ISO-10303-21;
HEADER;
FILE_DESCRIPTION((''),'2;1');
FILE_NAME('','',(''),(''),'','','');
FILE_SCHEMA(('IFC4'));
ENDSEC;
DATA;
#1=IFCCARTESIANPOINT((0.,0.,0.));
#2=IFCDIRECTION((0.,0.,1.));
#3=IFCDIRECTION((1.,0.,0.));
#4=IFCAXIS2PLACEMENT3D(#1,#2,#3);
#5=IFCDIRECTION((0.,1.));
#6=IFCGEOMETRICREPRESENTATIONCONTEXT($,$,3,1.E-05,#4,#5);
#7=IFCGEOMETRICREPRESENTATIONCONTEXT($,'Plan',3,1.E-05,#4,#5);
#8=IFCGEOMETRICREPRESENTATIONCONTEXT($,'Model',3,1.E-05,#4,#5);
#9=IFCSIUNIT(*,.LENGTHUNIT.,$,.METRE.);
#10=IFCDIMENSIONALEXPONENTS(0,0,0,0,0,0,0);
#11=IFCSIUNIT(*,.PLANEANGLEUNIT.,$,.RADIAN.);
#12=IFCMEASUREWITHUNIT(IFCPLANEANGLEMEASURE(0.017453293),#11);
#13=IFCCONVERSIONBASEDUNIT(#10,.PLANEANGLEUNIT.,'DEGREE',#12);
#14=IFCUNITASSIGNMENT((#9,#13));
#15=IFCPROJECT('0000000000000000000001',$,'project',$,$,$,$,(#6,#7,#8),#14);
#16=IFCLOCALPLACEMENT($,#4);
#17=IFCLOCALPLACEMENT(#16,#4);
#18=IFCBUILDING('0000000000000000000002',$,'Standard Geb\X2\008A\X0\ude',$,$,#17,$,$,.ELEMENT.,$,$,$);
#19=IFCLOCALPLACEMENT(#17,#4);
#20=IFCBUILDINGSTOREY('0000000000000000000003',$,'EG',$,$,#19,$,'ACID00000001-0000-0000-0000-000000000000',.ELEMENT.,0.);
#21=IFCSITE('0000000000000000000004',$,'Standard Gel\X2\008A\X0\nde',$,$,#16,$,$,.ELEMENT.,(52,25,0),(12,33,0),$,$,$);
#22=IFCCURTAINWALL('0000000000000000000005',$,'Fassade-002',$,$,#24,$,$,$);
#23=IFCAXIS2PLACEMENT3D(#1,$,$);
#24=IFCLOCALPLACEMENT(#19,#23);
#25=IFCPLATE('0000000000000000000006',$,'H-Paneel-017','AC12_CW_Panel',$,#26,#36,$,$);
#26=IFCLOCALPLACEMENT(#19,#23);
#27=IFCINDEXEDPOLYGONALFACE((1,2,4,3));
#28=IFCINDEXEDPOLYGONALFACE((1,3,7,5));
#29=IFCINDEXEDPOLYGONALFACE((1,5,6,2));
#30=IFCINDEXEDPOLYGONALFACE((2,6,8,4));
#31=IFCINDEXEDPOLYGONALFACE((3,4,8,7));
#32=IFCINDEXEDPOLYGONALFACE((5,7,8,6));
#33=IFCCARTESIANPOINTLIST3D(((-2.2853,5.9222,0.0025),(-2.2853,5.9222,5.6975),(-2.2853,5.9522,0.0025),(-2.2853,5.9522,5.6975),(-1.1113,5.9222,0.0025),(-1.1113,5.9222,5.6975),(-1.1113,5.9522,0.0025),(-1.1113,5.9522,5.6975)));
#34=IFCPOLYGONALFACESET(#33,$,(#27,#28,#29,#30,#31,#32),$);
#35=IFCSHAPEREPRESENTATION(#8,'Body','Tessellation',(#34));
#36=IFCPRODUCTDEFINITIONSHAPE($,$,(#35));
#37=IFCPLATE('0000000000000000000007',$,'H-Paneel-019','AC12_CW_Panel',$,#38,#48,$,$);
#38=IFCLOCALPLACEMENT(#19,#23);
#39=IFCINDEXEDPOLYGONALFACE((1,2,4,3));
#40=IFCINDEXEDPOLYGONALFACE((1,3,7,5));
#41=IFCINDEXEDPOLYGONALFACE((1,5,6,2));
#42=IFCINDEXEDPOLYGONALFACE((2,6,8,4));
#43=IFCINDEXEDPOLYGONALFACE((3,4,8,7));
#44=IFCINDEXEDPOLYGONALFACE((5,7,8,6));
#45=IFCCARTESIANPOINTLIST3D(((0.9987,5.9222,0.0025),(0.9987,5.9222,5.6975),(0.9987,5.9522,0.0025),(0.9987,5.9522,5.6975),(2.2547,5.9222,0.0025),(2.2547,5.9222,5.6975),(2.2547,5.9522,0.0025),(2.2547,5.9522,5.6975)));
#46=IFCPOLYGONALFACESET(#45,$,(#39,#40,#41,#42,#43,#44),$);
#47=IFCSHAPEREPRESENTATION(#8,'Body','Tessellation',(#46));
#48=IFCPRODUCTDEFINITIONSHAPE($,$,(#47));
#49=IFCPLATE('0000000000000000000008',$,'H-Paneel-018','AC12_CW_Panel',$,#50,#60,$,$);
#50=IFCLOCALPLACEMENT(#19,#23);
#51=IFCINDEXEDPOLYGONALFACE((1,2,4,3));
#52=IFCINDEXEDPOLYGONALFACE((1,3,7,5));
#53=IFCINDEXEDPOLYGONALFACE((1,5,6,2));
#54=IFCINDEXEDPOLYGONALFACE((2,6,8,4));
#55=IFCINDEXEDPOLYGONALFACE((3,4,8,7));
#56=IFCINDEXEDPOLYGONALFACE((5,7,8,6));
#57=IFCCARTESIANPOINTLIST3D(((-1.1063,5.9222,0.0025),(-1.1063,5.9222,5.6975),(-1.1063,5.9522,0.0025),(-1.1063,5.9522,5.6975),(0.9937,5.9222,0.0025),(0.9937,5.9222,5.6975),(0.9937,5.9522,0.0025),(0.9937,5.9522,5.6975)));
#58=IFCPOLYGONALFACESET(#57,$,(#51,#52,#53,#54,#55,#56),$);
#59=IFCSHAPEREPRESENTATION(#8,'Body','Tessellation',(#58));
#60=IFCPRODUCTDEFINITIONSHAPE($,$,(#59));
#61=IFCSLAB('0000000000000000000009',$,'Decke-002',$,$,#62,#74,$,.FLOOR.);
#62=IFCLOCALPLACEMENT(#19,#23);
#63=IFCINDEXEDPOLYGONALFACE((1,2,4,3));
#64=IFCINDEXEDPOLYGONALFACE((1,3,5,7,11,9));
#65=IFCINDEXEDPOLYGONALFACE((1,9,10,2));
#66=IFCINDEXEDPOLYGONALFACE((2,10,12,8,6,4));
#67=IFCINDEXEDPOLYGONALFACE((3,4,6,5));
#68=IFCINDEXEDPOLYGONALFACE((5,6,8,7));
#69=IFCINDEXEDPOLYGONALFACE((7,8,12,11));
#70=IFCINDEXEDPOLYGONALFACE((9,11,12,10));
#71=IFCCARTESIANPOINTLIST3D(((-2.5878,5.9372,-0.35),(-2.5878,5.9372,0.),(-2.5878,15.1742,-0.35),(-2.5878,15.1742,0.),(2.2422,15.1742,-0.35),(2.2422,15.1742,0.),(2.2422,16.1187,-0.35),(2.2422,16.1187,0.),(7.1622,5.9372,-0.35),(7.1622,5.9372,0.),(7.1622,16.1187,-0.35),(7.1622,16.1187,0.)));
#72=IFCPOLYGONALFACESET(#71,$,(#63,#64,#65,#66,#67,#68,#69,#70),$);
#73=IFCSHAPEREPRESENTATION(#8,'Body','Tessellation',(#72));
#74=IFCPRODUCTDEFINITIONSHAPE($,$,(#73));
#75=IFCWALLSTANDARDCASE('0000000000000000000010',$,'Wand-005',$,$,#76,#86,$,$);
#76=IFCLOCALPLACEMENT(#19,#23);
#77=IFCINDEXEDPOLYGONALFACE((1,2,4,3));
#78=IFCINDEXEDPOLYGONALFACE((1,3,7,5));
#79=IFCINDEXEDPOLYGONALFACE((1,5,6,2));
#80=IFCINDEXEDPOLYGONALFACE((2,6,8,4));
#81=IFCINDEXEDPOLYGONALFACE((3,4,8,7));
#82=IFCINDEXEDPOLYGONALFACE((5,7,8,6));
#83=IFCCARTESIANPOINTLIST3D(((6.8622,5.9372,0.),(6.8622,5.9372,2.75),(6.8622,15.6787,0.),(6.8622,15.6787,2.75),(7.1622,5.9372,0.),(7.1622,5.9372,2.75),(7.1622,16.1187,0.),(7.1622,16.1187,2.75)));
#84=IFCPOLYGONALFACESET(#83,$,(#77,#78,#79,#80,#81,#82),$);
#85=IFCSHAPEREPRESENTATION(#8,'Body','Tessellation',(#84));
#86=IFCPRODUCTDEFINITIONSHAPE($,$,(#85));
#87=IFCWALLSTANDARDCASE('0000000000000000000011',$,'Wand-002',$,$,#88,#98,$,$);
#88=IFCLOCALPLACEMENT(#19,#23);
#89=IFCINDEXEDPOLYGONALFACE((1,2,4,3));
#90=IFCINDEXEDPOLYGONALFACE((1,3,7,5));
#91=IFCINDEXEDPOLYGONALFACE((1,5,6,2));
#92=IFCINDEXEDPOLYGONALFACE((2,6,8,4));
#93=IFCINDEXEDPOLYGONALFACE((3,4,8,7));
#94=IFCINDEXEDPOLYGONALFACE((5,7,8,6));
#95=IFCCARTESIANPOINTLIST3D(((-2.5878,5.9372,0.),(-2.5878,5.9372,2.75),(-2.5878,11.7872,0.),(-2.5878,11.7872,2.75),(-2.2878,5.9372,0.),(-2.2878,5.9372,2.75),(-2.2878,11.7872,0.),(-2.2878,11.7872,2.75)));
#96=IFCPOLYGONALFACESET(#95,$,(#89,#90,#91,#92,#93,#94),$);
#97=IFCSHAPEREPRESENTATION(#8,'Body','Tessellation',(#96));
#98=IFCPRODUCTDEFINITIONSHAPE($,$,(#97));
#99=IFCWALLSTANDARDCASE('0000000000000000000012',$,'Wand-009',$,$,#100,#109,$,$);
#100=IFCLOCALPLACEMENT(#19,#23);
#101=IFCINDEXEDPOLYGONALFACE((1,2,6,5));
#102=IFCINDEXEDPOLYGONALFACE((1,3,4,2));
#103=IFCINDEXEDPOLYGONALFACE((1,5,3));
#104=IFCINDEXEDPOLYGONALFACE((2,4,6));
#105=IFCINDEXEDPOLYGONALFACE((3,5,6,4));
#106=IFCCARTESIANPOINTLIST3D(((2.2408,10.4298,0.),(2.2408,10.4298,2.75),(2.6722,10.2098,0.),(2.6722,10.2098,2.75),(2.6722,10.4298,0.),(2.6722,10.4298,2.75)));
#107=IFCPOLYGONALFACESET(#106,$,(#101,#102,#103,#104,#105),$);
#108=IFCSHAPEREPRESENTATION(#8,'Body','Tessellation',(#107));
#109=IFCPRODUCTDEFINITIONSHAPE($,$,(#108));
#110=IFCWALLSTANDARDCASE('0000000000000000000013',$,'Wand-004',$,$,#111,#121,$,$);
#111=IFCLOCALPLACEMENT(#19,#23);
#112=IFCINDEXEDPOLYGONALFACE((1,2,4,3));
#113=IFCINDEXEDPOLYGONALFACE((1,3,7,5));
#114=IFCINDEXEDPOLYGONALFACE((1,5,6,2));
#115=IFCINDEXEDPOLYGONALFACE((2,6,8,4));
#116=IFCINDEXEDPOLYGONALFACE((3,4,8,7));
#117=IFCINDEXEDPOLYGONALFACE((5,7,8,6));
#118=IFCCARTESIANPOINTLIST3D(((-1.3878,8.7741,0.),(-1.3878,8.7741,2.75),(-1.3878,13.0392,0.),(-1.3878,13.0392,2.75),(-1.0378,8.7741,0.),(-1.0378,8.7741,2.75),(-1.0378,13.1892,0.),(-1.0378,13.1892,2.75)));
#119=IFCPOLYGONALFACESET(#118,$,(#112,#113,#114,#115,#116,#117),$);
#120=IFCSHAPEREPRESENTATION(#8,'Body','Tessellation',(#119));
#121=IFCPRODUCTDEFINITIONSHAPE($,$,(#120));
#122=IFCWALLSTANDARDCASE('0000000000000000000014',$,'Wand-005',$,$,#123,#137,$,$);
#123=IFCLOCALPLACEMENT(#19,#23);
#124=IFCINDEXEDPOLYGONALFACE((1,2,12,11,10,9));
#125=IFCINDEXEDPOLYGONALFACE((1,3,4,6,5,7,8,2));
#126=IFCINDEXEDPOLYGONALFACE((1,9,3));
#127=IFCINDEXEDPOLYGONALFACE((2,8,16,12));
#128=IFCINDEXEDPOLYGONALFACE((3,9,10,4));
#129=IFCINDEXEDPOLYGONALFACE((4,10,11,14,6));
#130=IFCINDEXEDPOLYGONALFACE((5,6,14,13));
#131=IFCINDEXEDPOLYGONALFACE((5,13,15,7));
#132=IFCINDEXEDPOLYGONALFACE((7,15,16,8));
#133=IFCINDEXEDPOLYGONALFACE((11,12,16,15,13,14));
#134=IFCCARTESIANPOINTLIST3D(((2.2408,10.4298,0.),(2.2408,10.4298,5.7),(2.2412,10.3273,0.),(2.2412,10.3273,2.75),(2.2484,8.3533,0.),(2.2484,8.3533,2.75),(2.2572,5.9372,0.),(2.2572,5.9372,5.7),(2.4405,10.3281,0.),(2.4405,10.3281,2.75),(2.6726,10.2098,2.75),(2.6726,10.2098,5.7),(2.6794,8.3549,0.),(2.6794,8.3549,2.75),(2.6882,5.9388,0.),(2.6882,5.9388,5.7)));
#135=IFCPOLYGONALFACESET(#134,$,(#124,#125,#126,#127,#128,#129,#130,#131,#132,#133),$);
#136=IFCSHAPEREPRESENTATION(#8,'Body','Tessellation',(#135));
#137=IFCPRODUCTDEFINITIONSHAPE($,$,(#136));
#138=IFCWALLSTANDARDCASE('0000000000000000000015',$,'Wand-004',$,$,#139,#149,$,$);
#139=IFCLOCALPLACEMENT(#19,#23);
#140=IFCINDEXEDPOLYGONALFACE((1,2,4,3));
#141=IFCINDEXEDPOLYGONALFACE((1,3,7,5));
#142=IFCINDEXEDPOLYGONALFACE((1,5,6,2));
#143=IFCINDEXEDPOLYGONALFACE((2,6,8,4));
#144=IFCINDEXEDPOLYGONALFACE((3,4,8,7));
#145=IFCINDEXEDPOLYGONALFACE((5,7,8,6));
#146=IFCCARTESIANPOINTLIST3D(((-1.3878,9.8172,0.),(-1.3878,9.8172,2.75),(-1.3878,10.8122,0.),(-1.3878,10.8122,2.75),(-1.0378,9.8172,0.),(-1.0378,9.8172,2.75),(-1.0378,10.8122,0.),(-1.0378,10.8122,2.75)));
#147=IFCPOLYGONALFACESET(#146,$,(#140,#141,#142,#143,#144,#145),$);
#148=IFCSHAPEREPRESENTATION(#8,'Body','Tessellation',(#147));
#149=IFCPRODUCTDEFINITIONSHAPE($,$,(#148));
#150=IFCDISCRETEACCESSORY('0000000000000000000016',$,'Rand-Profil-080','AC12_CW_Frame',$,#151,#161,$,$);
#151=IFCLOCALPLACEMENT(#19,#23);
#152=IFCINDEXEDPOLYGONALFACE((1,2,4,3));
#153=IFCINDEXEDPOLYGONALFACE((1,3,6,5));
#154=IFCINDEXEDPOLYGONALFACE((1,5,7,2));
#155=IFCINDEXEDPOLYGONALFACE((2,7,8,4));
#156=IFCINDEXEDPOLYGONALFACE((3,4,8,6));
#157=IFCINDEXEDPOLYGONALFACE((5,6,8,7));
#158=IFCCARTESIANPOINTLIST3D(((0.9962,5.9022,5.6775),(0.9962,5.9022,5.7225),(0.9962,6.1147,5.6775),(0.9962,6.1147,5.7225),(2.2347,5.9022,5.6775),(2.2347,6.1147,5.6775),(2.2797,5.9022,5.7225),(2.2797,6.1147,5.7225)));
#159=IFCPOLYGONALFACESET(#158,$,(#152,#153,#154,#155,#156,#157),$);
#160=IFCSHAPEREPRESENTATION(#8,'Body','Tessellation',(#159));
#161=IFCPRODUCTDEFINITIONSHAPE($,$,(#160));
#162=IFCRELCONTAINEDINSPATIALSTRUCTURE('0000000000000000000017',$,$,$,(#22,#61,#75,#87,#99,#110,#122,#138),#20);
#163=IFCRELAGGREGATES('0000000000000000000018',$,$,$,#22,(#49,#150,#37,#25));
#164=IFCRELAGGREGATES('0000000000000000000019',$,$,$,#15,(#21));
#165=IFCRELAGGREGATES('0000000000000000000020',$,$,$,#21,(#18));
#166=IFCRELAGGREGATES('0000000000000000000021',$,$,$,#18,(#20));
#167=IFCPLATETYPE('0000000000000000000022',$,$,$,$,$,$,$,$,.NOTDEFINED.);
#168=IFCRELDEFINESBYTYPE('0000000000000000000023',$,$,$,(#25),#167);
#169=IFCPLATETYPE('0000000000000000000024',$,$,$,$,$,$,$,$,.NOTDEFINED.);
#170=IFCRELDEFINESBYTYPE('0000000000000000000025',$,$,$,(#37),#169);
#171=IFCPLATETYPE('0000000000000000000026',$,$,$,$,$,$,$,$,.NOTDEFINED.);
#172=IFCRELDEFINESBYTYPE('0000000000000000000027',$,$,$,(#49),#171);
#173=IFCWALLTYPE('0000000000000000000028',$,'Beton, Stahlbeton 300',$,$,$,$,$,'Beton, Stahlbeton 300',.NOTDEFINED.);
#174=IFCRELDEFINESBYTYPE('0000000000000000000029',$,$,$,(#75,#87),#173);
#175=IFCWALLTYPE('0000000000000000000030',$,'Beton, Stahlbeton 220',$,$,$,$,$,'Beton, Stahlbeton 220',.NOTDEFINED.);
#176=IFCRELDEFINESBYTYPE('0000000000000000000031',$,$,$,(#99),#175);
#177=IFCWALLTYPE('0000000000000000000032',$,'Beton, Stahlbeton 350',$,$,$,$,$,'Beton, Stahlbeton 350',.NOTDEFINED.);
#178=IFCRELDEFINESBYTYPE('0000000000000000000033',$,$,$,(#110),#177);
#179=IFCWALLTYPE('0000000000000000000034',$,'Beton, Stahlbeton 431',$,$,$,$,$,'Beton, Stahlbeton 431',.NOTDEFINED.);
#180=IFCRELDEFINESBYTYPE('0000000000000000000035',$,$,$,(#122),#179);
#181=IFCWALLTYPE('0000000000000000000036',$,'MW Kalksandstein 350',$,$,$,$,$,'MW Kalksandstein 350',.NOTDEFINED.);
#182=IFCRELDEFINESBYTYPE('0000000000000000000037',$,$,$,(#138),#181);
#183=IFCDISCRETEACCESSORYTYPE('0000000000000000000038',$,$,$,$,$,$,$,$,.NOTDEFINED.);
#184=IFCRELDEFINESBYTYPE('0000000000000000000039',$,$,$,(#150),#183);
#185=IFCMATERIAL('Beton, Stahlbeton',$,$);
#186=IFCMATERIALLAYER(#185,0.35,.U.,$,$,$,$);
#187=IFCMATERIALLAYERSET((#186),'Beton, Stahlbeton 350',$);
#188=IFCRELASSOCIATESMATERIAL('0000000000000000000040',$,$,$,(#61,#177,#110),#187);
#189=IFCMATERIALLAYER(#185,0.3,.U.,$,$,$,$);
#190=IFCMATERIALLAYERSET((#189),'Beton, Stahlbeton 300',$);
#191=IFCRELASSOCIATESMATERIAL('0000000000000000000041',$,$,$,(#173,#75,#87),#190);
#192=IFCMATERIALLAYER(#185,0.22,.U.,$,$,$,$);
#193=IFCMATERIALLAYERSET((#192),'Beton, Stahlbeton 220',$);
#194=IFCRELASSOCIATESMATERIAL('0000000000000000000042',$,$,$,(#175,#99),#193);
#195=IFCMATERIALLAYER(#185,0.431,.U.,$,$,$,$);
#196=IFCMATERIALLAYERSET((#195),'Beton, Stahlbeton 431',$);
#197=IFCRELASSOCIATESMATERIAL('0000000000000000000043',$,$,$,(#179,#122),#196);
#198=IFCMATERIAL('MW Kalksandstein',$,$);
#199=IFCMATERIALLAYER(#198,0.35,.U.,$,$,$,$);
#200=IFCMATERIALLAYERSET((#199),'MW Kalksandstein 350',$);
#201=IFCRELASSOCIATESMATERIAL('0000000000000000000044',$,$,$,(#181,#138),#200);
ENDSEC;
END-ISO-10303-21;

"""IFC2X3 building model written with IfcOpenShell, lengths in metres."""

from ifc_helpers import new_model, entity, si_unit, converted_unit, direction, frame, frame_2d, origin_with_axes, place, context, project, spatial, polyline, rectangle, outline, extrude, source, transform, mapped, material, layer, layer_set, layer_usage, type_object, type_shapes, element, aggregate, save


model = new_model("IFC2X3")

# Units and contexts
model_context = context("Model", 3, precision=1e-05, world=origin_with_axes(), true_north=direction((0.0, 1.0)))
plan_context = context("Plan", 3, precision=1e-05, world=origin_with_axes(), true_north=direction((0.0, 1.0)))
context_of_model = context(None, 3, precision=1e-05, world=origin_with_axes(), true_north=direction((0.0, 1.0)))
ifc_project = project(units=[si_unit("LENGTHUNIT", "METRE"), converted_unit("PLANEANGLEUNIT", "DEGREE", entity("IfcPlaneAngleMeasure", 0.017453293), si_unit("PLANEANGLEUNIT", "RADIAN"), dimensions=[0, 0, 0, 0, 0, 0, 0])], contexts=[context_of_model, plan_context, model_context])

# Site, building, storey
site_placement = place(None, origin_with_axes())
site = spatial("IfcSite", under=ifc_project, at=site_placement, Name="Standard Gel\u008ande", CompositionType="ELEMENT", RefLatitude=(52, 25, 0), RefLongitude=(12, 33, 0))
building_placement = place(site_placement, origin_with_axes())
building = spatial("IfcBuilding", under=site, at=building_placement, Name="Standard Geb\u008aude", CompositionType="ELEMENT")
storey_placement = place(building_placement, origin_with_axes())
storey = spatial("IfcBuildingStorey", under=building, at=storey_placement, Name="EG", LongName="ACID00000001-0000-0000-0000-000000000000", CompositionType="ELEMENT", Elevation=0.0)

# Curtain wall, plates
curtain_wall_placement = place(storey_placement, frame((-2.2878, 5.9372, 0.0), z_axis=(0.0, 0.0, 1.0), x_axis=(1.0, 0.0, 0.0)))
curtain_wall = element("IfcCurtainWall", 1, at=curtain_wall_placement, inside=storey, Name="Fassade-002")
plate_type_1 = type_object("IfcPlateType", PredefinedType="NOTDEFINED")
shared_shape_1 = source(origin_with_axes(), model_context, "Body", "SweptSolid", [
    extrude(outline(polyline([(0.0, 0.0), (1.174, 0.0), (1.174, -0.03), (0.0, -0.03), (0.0, 0.0)])), origin_with_axes(), (0.0, 0.0, 1.0), 5.695),
])
type_shapes(plate_type_1, [shared_shape_1])
plate_1_placement = place(storey_placement, frame((-2.2853, 5.9522, 0.0025), z_axis=(0.0, 0.0, 1.0), x_axis=(1.0, 0.0, 0.0)))
plate_1 = element("IfcPlate", 2, at=plate_1_placement, type_object=plate_type_1, Name="H-Paneel-017", Description="AC12_CW_Panel", context=model_context, shape_type="MappedRepresentation", body=[
    mapped(shared_shape_1, transform((0.0, 0.0, 0.0), scale=1.0)),
])
plate_type_2 = type_object("IfcPlateType", PredefinedType="NOTDEFINED")
shared_shape_2 = source(origin_with_axes(), model_context, "Body", "SweptSolid", [
    extrude(outline(polyline([(0.0, 0.0), (1.256, 0.0), (1.256, -0.03), (0.0, -0.03), (0.0, 0.0)])), origin_with_axes(), (0.0, 0.0, 1.0), 5.695),
])
type_shapes(plate_type_2, [shared_shape_2])
plate_2_placement = place(storey_placement, frame((0.9987, 5.9522, 0.0025), z_axis=(0.0, 0.0, 1.0), x_axis=(1.0, 0.0, 0.0)))
plate_2 = element("IfcPlate", 3, at=plate_2_placement, type_object=plate_type_2, Name="H-Paneel-019", Description="AC12_CW_Panel", context=model_context, shape_type="MappedRepresentation", body=[
    mapped(shared_shape_2, transform((0.0, 0.0, 0.0), scale=1.0)),
])
plate_type_3 = type_object("IfcPlateType", PredefinedType="NOTDEFINED")
shared_shape_3 = source(origin_with_axes(), model_context, "Body", "SweptSolid", [
    extrude(outline(polyline([(0.0, 0.0), (2.1, 0.0), (2.1, -0.03), (0.0, -0.03), (0.0, 0.0)])), origin_with_axes(), (0.0, 0.0, 1.0), 5.695),
])
type_shapes(plate_type_3, [shared_shape_3])
plate_3_placement = place(storey_placement, frame((-1.1063, 5.9522, 0.0025), z_axis=(0.0, 0.0, 1.0), x_axis=(1.0, 0.0, 0.0)))
plate_3 = element("IfcPlate", 4, at=plate_3_placement, type_object=plate_type_3, Name="H-Paneel-018", Description="AC12_CW_Panel", context=model_context, shape_type="MappedRepresentation", body=[
    mapped(shared_shape_3, transform((0.0, 0.0, 0.0), scale=1.0)),
])

# Slab
ifc_material_1 = material(Name="Beton, Stahlbeton")
ifc_layer_1 = layer(ifc_material_1, 0.35, ventilated="UNKNOWN")
ifc_layer_set_1 = layer_set([ifc_layer_1], Name="Beton, Stahlbeton 350")
ifc_layer_usage_1 = layer_usage(ifc_layer_set_1, "AXIS3", "NEGATIVE", 0.35)
slab_placement = place(storey_placement, frame((-2.5878, 5.9372, -0.35), z_axis=(0.0, 0.0, 1.0), x_axis=(0.0, 1.0, 0.0)))
element("IfcSlab", 5, at=slab_placement, inside=storey, material=ifc_layer_usage_1, Name="Decke-002", PredefinedType="FLOOR", context=model_context, shape_type="SweptSolid", body=[
    extrude(outline(polyline([(0.0, 0.0), (9.237, 0.0), (9.237, -4.83), (10.1815, -4.83), (10.1815, -9.75), (0.0, -9.75), (0.0, 0.0)])), origin_with_axes(), (0.0, 0.0, 1.0), 0.35),
])

# Walls
ifc_layer_2 = layer(ifc_material_1, 0.3, ventilated="UNKNOWN")
ifc_layer_set_2 = layer_set([ifc_layer_2], Name="Beton, Stahlbeton 300")
ifc_layer_usage_2 = layer_usage(ifc_layer_set_2, "AXIS2", "POSITIVE", 0.0)
wall_type_1 = type_object("IfcWallType", Name="Beton, Stahlbeton 300", ElementType="Beton, Stahlbeton 300", PredefinedType="NOTDEFINED", material=ifc_layer_set_2)
wall_1_placement = place(storey_placement, frame((7.1622, 5.9372, 0.0), z_axis=(0.0, 0.0, 1.0), x_axis=(0.0, 1.0, 0.0)))
element("IfcWallStandardCase", 6, at=wall_1_placement, inside=storey, type_object=wall_type_1, material=ifc_layer_usage_2, Name="Wand-005", context=model_context, shape_type="SweptSolid", body=[
    extrude(outline(polyline([(0.0, 0.0), (10.1815, 0.0), (9.7415, 0.3), (0.0, 0.3), (0.0, 0.0)])), origin_with_axes(), (0.0, 0.0, 1.0), 2.75),
])
ifc_layer_usage_3 = layer_usage(ifc_layer_set_2, "AXIS2", "POSITIVE", 0.0)
wall_2_placement = place(storey_placement, frame((-2.5878, 11.7872, 0.0), z_axis=(0.0, 0.0, 1.0), x_axis=(0.0, -1.0, 0.0)))
element("IfcWallStandardCase", 7, at=wall_2_placement, inside=storey, type_object=wall_type_1, material=ifc_layer_usage_3, Name="Wand-002", context=model_context, shape_type="SweptSolid", body=[
    extrude(outline(polyline([(0.0, 0.0), (5.85, 0.0), (5.85, 0.3), (0.0, 0.3), (0.0, 0.0)])), origin_with_axes(), (0.0, 0.0, 1.0), 2.75),
])
ifc_layer_3 = layer(ifc_material_1, 0.22, ventilated="UNKNOWN")
ifc_layer_set_3 = layer_set([ifc_layer_3], Name="Beton, Stahlbeton 220")
ifc_layer_usage_4 = layer_usage(ifc_layer_set_3, "AXIS2", "NEGATIVE", 0.0)
wall_type_2 = type_object("IfcWallType", Name="Beton, Stahlbeton 220", ElementType="Beton, Stahlbeton 220", PredefinedType="NOTDEFINED", material=ifc_layer_set_3)
wall_3_placement = place(storey_placement, frame((2.6722, 10.2098, 0.0), z_axis=(0.0, 0.0, 1.0), x_axis=(-1.0, 0.0, 0.0)))
element("IfcWallStandardCase", 8, at=wall_3_placement, inside=storey, type_object=wall_type_2, material=ifc_layer_usage_4, Name="Wand-009", context=model_context, shape_type="SweptSolid", body=[
    extrude(outline(polyline([(0.0, -0.22), (0.4313, -0.22), (0.0, 0.0), (0.0, 0.0), (0.0, -0.22)])), origin_with_axes(), (0.0, 0.0, 1.0), 2.75),
])
ifc_layer_usage_5 = layer_usage(ifc_layer_set_1, "AXIS2", "NEGATIVE", 0.0)
wall_type_3 = type_object("IfcWallType", Name="Beton, Stahlbeton 350", ElementType="Beton, Stahlbeton 350", PredefinedType="NOTDEFINED", material=ifc_layer_set_1)
wall_4_placement = place(storey_placement, frame((-1.3878, 8.7741, 0.0), z_axis=(0.0, 0.0, 1.0), x_axis=(0.0, 1.0, 0.0)))
element("IfcWallStandardCase", 9, at=wall_4_placement, inside=storey, type_object=wall_type_3, material=ifc_layer_usage_5, Name="Wand-004", context=model_context, shape_type="SweptSolid", body=[
    extrude(outline(polyline([(0.0, -0.35), (4.4151, -0.35), (4.2651, 0.0), (0.0, 0.0), (0.0, -0.35)])), origin_with_axes(), (0.0, 0.0, 1.0), 2.75),
])

# Wall, opening
ifc_layer_4 = layer(ifc_material_1, 0.431, ventilated="UNKNOWN")
ifc_layer_set_4 = layer_set([ifc_layer_4], Name="Beton, Stahlbeton 431")
ifc_layer_usage_6 = layer_usage(ifc_layer_set_4, "AXIS2", "NEGATIVE", 0.0)
wall_type_4 = type_object("IfcWallType", Name="Beton, Stahlbeton 431", ElementType="Beton, Stahlbeton 431", PredefinedType="NOTDEFINED", material=ifc_layer_set_4)
wall_5_placement = place(storey_placement, frame((2.2572, 5.9372, 0.0), z_axis=(0.0, 0.0, 1.0), x_axis=(-0.003631, 0.999993, 0.0)))
wall_5 = element("IfcWallStandardCase", 10, at=wall_5_placement, inside=storey, type_object=wall_type_4, material=ifc_layer_usage_6, Name="Wand-005", context=model_context, shape_type="SweptSolid", body=[
    extrude(outline(polyline([(0.0, -0.431), (4.2711, -0.431), (4.4926, 0.0), (0.0, 0.0), (0.0, -0.431)])), origin_with_axes(), (0.0, 0.0, 1.0), 5.7),
])
opening_placement = place(wall_5_placement, frame((3.4032, -0.431, 0.0), z_axis=(0.0, 0.0, 1.0), x_axis=(1.0, 0.0, 0.0)))
element("IfcOpeningElement", 11, at=opening_placement, cuts=wall_5, ObjectType="Opening", context=model_context, shape_type="SweptSolid", body=[
    extrude(rectangle(XDim=1.974, YDim=2.75, at=frame_2d((0.0, 1.375), x_axis=(1.0, 0.0))), frame((0.0, 0.0, 0.0), z_axis=(0.0, 1.0, 0.0), x_axis=(-1.0, 0.0, 0.0)), (0.0, 0.0, 1.0), 0.431),
])

# Wall
ifc_material_2 = material(Name="MW Kalksandstein")
ifc_layer_5 = layer(ifc_material_2, 0.35, ventilated="UNKNOWN")
ifc_layer_set_5 = layer_set([ifc_layer_5], Name="MW Kalksandstein 350")
ifc_layer_usage_7 = layer_usage(ifc_layer_set_5, "AXIS2", "NEGATIVE", 0.0)
wall_type_5 = type_object("IfcWallType", Name="MW Kalksandstein 350", ElementType="MW Kalksandstein 350", PredefinedType="NOTDEFINED", material=ifc_layer_set_5)
wall_6_placement = place(storey_placement, frame((-1.3878, 9.8172, 0.0), z_axis=(0.0, 0.0, 1.0), x_axis=(0.0, 1.0, 0.0)))
element("IfcWallStandardCase", 12, at=wall_6_placement, inside=storey, type_object=wall_type_5, material=ifc_layer_usage_7, Name="Wand-004", context=model_context, shape_type="SweptSolid", body=[
    extrude(outline(polyline([(0.0, -0.35), (0.995, -0.35), (0.995, 0.0), (0.0, 0.0), (0.0, -0.35)])), origin_with_axes(), (0.0, 0.0, 1.0), 2.75),
])

# Discrete accessory
discrete_accessory_type_1 = type_object("IfcDiscreteAccessoryType")
shared_shape_4 = source(origin_with_axes(), model_context, "Body", "SweptSolid", [
    extrude(outline(polyline([(0.0, 0.0), (0.045, 0.0), (0.045, -1.2385), (0.0, -1.2835), (0.0, 0.0)])), origin_with_axes(), (0.0, 0.0, 1.0), 0.2125),
])
type_shapes(discrete_accessory_type_1, [shared_shape_4])
discrete_accessory_1_placement = place(storey_placement, frame((0.9962, 5.9022, 5.7225), z_axis=(0.0, 1.0, 0.0), x_axis=(0.0, 0.0, -1.0)))
discrete_accessory_1 = element("IfcDiscreteAccessory", 13, at=discrete_accessory_1_placement, type_object=discrete_accessory_type_1, Name="Rand-Profil-080", Description="AC12_CW_Frame", context=model_context, shape_type="MappedRepresentation", body=[
    mapped(shared_shape_4, transform((0.0, 0.0, 0.0), scale=1.0)),
])
aggregate(curtain_wall, [plate_3, discrete_accessory_1, plate_2, plate_1])

save(model, "model.ifc")
